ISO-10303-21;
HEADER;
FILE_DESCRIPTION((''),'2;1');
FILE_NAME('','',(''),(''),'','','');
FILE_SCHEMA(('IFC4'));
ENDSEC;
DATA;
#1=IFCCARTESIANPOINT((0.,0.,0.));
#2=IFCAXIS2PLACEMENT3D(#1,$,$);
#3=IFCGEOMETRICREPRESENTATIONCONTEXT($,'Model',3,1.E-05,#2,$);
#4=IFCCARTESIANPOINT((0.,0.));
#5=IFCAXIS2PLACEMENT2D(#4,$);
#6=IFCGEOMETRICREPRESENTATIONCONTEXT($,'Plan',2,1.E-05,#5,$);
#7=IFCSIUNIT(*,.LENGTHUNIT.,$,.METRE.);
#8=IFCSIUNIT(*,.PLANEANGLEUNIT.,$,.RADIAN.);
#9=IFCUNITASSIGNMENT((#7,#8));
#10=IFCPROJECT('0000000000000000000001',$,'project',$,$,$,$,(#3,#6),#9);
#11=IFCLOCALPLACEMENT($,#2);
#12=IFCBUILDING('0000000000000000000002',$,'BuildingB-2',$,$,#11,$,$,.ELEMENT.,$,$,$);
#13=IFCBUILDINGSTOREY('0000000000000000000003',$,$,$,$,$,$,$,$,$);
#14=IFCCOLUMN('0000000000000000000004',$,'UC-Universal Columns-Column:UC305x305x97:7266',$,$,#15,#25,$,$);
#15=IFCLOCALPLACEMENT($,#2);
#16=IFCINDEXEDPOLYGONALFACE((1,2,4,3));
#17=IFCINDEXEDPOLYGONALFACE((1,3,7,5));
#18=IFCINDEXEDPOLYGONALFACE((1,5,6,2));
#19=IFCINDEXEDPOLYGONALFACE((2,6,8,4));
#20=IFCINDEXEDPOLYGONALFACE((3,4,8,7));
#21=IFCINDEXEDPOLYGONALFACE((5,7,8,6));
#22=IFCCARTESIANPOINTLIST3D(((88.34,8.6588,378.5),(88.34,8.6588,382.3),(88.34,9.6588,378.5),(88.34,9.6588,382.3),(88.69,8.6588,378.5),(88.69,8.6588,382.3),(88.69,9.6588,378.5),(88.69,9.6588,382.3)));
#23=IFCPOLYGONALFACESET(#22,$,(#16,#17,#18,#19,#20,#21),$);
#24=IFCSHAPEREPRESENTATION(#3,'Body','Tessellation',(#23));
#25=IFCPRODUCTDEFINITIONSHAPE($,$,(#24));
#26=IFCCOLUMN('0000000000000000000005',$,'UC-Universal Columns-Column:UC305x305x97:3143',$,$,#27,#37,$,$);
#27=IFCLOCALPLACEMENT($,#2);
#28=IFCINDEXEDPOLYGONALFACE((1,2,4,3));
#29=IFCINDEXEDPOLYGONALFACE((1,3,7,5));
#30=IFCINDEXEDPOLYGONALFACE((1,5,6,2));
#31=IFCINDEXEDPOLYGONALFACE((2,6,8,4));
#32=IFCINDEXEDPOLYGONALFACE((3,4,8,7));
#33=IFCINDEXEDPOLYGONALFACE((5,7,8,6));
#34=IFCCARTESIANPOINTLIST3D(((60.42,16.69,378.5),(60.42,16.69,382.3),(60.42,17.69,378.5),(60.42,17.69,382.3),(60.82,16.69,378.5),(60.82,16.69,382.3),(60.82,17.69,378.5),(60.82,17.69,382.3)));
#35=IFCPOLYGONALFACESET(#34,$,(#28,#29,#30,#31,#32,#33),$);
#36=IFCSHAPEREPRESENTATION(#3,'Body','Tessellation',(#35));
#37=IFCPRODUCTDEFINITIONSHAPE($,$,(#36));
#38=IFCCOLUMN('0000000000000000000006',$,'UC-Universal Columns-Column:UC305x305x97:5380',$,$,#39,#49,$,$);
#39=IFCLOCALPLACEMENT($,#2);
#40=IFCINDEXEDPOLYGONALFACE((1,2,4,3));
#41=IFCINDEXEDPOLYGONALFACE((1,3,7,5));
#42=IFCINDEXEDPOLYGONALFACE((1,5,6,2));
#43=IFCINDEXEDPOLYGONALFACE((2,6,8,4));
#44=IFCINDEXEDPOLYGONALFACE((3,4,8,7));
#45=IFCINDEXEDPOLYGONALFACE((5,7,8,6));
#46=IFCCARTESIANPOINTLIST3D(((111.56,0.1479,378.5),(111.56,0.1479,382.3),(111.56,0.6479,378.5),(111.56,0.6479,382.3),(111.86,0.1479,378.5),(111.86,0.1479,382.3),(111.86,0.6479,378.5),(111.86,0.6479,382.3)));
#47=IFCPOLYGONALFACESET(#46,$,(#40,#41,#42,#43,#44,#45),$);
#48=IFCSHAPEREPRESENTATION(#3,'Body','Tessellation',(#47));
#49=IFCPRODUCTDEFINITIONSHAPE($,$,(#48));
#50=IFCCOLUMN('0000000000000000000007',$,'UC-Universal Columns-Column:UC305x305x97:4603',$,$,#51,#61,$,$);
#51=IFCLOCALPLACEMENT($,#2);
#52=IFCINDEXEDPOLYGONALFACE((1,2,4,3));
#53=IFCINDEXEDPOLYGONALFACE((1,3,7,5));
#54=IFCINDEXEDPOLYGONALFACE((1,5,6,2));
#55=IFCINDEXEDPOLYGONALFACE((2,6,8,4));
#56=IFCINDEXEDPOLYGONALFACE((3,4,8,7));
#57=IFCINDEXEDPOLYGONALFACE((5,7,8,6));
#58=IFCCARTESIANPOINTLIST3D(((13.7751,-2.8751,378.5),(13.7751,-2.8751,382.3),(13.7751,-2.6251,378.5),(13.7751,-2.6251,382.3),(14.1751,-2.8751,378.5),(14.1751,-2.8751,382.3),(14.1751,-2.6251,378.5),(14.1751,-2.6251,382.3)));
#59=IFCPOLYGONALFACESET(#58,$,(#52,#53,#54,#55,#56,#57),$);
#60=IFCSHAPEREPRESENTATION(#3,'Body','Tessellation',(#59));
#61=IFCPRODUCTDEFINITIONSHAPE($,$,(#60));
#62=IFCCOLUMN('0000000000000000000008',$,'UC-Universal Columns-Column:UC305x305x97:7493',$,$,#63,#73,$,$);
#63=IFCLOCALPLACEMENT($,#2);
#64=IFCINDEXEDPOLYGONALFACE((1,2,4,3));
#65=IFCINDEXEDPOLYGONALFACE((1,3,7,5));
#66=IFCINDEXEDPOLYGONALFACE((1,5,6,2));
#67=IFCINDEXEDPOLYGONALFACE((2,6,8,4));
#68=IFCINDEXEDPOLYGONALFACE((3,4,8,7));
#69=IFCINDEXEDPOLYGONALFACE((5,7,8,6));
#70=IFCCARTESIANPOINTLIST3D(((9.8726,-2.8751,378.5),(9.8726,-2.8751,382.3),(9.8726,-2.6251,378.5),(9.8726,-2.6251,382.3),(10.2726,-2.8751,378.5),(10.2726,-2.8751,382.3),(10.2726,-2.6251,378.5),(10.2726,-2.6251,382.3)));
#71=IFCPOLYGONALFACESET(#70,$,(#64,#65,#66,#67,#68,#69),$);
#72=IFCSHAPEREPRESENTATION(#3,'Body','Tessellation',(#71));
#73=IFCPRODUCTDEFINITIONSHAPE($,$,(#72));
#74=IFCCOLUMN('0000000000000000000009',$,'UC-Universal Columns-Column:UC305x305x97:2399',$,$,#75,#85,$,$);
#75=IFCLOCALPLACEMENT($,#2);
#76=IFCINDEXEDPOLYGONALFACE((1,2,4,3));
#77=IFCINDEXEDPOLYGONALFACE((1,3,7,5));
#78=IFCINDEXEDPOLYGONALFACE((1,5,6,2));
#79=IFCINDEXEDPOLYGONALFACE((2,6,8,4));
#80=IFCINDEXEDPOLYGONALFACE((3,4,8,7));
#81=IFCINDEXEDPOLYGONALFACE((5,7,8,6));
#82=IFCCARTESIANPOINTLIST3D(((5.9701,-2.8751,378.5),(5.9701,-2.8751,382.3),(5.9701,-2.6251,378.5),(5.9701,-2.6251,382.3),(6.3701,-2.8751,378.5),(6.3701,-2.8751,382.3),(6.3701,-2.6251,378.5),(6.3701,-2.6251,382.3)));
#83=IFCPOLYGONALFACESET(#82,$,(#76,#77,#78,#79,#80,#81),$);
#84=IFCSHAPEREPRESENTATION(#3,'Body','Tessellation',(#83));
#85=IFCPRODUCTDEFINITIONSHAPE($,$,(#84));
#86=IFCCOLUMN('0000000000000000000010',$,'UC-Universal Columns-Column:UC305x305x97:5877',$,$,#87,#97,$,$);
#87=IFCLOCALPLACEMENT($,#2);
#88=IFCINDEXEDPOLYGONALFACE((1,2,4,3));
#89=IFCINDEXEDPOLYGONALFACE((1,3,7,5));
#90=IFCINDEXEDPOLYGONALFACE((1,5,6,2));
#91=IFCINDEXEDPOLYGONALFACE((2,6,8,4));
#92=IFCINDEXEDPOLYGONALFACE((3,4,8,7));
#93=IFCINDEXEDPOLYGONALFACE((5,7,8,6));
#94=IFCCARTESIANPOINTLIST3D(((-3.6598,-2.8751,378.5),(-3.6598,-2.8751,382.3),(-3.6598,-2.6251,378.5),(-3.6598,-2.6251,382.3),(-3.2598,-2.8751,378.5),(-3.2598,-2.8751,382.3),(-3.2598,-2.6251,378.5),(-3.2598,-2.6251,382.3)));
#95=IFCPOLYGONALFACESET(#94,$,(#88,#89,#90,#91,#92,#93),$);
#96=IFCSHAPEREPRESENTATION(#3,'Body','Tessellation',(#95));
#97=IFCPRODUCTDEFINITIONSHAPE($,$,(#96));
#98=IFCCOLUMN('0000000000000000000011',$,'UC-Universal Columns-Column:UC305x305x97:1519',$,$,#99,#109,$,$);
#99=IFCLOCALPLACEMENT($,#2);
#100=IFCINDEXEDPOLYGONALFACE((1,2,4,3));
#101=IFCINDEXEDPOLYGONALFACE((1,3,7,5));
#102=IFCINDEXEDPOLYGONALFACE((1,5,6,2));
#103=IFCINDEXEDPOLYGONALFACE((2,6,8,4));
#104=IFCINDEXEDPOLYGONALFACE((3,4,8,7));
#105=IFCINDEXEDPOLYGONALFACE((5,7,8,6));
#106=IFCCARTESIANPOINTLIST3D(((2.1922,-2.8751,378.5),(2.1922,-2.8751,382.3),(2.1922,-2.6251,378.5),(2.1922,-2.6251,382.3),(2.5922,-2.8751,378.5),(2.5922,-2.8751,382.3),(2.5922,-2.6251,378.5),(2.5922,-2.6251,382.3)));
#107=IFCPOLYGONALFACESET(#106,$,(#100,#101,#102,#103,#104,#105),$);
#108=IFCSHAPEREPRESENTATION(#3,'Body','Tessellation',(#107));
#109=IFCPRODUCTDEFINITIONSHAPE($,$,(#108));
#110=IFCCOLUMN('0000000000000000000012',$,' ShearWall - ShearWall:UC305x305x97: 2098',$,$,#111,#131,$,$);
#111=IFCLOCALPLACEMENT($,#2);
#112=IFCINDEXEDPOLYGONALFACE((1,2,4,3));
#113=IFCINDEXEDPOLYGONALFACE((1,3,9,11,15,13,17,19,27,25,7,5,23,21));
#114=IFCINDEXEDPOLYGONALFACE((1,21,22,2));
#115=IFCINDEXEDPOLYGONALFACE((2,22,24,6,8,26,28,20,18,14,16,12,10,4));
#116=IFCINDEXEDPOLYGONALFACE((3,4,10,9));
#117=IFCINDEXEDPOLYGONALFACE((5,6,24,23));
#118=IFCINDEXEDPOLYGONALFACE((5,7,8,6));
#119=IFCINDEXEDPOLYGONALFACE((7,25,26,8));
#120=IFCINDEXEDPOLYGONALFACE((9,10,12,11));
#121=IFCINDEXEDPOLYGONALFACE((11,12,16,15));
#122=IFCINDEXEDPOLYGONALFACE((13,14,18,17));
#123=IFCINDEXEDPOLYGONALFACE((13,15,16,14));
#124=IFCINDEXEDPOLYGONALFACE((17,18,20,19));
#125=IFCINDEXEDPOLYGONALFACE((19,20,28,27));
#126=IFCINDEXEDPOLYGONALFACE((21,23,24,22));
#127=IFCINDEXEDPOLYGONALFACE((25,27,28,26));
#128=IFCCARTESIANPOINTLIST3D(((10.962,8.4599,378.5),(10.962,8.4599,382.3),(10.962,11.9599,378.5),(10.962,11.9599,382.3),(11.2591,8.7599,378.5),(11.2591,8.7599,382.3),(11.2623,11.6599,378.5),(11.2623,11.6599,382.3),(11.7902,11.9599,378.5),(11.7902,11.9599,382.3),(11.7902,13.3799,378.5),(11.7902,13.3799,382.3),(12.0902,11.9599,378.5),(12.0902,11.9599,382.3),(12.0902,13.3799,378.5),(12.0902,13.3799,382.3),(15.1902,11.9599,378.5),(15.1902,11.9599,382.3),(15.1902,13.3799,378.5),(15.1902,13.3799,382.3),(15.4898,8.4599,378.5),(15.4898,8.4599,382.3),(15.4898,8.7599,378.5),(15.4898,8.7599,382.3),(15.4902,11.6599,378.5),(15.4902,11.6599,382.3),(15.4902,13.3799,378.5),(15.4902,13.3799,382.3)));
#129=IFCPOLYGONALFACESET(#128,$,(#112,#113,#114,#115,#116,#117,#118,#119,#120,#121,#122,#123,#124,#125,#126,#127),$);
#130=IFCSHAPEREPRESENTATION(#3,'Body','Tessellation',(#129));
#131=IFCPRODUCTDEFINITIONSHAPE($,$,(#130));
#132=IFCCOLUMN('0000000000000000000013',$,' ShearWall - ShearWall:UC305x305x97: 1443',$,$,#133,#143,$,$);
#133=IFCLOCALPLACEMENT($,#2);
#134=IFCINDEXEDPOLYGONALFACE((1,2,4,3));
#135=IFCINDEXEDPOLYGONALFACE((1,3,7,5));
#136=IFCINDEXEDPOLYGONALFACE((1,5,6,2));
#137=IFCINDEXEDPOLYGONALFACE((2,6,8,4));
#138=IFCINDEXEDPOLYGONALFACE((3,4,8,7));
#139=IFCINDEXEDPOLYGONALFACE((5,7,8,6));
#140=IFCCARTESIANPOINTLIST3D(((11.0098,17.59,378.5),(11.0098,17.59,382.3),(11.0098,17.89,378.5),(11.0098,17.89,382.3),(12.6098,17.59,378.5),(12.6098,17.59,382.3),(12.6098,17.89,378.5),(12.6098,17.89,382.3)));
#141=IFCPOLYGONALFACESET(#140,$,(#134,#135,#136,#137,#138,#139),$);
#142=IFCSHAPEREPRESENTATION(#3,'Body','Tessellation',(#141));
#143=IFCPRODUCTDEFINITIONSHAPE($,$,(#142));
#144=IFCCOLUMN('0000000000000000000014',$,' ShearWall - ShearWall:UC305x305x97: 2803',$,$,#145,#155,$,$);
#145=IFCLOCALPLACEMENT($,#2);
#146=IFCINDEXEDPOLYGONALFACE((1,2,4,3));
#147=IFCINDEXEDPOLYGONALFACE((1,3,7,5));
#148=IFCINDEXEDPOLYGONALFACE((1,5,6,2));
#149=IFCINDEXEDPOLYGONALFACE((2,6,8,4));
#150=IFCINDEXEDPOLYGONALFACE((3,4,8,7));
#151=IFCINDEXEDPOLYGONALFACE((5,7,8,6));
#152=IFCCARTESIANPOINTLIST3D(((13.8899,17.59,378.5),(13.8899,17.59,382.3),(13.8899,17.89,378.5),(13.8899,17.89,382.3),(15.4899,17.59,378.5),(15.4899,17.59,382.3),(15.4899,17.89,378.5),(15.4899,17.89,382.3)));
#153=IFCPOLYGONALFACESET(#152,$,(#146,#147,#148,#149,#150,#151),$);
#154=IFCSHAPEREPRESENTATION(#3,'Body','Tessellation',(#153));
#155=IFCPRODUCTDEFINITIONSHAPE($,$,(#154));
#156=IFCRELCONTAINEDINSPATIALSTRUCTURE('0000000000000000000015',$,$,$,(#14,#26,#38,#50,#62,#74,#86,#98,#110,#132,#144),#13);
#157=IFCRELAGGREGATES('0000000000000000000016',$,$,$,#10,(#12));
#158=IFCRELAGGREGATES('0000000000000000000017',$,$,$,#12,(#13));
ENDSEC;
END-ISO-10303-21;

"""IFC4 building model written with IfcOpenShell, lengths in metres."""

from ifc_helpers import new_model, si_unit, origin, origin_with_axes, origin_2d, place, context, project, spatial, polyline, outline, extrude, element, save


model = new_model("IFC4")

# Units and contexts
model_context = context("Model", 3, precision=1e-05, world=origin())
plan_context = context("Plan", 2, precision=1e-05, world=origin_2d())
ifc_project = project(units=[si_unit("LENGTHUNIT", "METRE"), si_unit("PLANEANGLEUNIT", "RADIAN")], contexts=[model_context, plan_context])

# Building, storey
building_placement = place(None, origin())
building = spatial("IfcBuilding", under=ifc_project, at=building_placement, Name="BuildingB-2", CompositionType="ELEMENT")
storey = spatial("IfcBuildingStorey", under=building)

# Columns
element("IfcColumn", 1, inside=storey, Name="UC-Universal Columns-Column:UC305x305x97:7266", context=model_context, shape_type="SweptSolid", body=[
    extrude(outline(polyline([(88.34, 8.6588, 382.3), (88.69, 8.6588, 382.3), (88.69, 9.6588, 382.3), (88.34, 9.6588, 382.3), (88.34, 8.6588, 382.3)])), None, (0.0, 0.0, -1.0), 3.8),
])
element("IfcColumn", 2, inside=storey, Name="UC-Universal Columns-Column:UC305x305x97:3143", context=model_context, shape_type="SweptSolid", body=[
    extrude(outline(polyline([(60.42, 17.69, 382.3), (60.82, 17.69, 382.3), (60.82, 16.69, 382.3), (60.42, 16.69, 382.3), (60.42, 17.69, 382.3)])), None, (0.0, 0.0, -1.0), 3.8),
])
element("IfcColumn", 3, inside=storey, Name="UC-Universal Columns-Column:UC305x305x97:5380", context=model_context, shape_type="SweptSolid", body=[
    extrude(outline(polyline([(111.56, 0.6479, 382.3), (111.86, 0.6479, 382.3), (111.86, 0.1479, 382.3), (111.56, 0.1479, 382.3), (111.56, 0.6479, 382.3)])), None, (0.0, 0.0, -1.0), 3.8),
])
element("IfcColumn", 4, inside=storey, Name="UC-Universal Columns-Column:UC305x305x97:4603", context=model_context, shape_type="SweptSolid", body=[
    extrude(outline(polyline([(13.7751, -2.8751, 382.3), (13.7751, -2.6251, 382.3), (14.1751, -2.6251, 382.3), (14.1751, -2.8751, 382.3), (13.7751, -2.8751, 382.3)])), None, (0.0, 0.0, -1.0), 3.8),
])
element("IfcColumn", 5, inside=storey, Name="UC-Universal Columns-Column:UC305x305x97:7493", context=model_context, shape_type="SweptSolid", body=[
    extrude(outline(polyline([(9.8726, -2.8751, 382.3), (9.8726, -2.6251, 382.3), (10.2726, -2.6251, 382.3), (10.2726, -2.8751, 382.3), (9.8726, -2.8751, 382.3)])), None, (0.0, 0.0, -1.0), 3.8),
])
element("IfcColumn", 6, inside=storey, Name="UC-Universal Columns-Column:UC305x305x97:2399", context=model_context, shape_type="SweptSolid", body=[
    extrude(outline(polyline([(5.9701, -2.8751, 382.3), (5.9701, -2.6251, 382.3), (6.3701, -2.6251, 382.3), (6.3701, -2.8751, 382.3), (5.9701, -2.8751, 382.3)])), None, (0.0, 0.0, -1.0), 3.8),
])
element("IfcColumn", 7, inside=storey, Name="UC-Universal Columns-Column:UC305x305x97:5877", context=model_context, shape_type="SweptSolid", body=[
    extrude(outline(polyline([(-3.6598, -2.8751, 382.3), (-3.6598, -2.6251, 382.3), (-3.2598, -2.6251, 382.3), (-3.2598, -2.8751, 382.3), (-3.6598, -2.8751, 382.3)])), None, (0.0, 0.0, -1.0), 3.8),
])
element("IfcColumn", 8, inside=storey, Name="UC-Universal Columns-Column:UC305x305x97:1519", context=model_context, shape_type="SweptSolid", body=[
    extrude(outline(polyline([(2.1922, -2.8751, 382.3), (2.1922, -2.6251, 382.3), (2.5922, -2.6251, 382.3), (2.5922, -2.8751, 382.3), (2.1922, -2.8751, 382.3)])), None, (0.0, 0.0, -1.0), 3.8),
])
column_1_placement = place(None, origin_with_axes())
element("IfcColumn", 9, at=column_1_placement, inside=storey, Name=" ShearWall - ShearWall:UC305x305x97: 2098", context=model_context, shape_type="SweptSolid", body=[
    extrude(outline(polyline([(10.962, 8.4599, 382.3), (15.4898, 8.4599, 382.3), (15.4898, 8.7599, 382.3), (11.2591, 8.7599, 382.3), (11.2623, 11.6599, 382.3), (15.4902, 11.6599, 382.3), (15.4902, 13.3799, 382.3), (15.1902, 13.3799, 382.3), (15.1902, 11.9599, 382.3), (12.0902, 11.9599, 382.3), (12.0902, 13.3799, 382.3), (11.7902, 13.3799, 382.3), (11.7902, 11.9599, 382.3), (10.962, 11.9599, 382.3), (10.962, 8.4599, 382.3)])), None, (0.0, 0.0, -1.0), 3.8),
])
column_2_placement = place(None, origin_with_axes())
element("IfcColumn", 10, at=column_2_placement, inside=storey, Name=" ShearWall - ShearWall:UC305x305x97: 1443", context=model_context, shape_type="SweptSolid", body=[
    extrude(outline(polyline([(11.0098, 17.59, 382.3), (11.0098, 17.89, 382.3), (12.6098, 17.89, 382.3), (12.6098, 17.59, 382.3), (11.0098, 17.59, 382.3)])), None, (0.0, 0.0, -1.0), 3.8),
])
column_3_placement = place(None, origin_with_axes())
element("IfcColumn", 11, at=column_3_placement, inside=storey, Name=" ShearWall - ShearWall:UC305x305x97: 2803", context=model_context, shape_type="SweptSolid", body=[
    extrude(outline(polyline([(13.8899, 17.59, 382.3), (13.8899, 17.89, 382.3), (15.4899, 17.89, 382.3), (15.4899, 17.59, 382.3), (13.8899, 17.59, 382.3)])), None, (0.0, 0.0, -1.0), 3.8),
])

save(model, "model.ifc")
